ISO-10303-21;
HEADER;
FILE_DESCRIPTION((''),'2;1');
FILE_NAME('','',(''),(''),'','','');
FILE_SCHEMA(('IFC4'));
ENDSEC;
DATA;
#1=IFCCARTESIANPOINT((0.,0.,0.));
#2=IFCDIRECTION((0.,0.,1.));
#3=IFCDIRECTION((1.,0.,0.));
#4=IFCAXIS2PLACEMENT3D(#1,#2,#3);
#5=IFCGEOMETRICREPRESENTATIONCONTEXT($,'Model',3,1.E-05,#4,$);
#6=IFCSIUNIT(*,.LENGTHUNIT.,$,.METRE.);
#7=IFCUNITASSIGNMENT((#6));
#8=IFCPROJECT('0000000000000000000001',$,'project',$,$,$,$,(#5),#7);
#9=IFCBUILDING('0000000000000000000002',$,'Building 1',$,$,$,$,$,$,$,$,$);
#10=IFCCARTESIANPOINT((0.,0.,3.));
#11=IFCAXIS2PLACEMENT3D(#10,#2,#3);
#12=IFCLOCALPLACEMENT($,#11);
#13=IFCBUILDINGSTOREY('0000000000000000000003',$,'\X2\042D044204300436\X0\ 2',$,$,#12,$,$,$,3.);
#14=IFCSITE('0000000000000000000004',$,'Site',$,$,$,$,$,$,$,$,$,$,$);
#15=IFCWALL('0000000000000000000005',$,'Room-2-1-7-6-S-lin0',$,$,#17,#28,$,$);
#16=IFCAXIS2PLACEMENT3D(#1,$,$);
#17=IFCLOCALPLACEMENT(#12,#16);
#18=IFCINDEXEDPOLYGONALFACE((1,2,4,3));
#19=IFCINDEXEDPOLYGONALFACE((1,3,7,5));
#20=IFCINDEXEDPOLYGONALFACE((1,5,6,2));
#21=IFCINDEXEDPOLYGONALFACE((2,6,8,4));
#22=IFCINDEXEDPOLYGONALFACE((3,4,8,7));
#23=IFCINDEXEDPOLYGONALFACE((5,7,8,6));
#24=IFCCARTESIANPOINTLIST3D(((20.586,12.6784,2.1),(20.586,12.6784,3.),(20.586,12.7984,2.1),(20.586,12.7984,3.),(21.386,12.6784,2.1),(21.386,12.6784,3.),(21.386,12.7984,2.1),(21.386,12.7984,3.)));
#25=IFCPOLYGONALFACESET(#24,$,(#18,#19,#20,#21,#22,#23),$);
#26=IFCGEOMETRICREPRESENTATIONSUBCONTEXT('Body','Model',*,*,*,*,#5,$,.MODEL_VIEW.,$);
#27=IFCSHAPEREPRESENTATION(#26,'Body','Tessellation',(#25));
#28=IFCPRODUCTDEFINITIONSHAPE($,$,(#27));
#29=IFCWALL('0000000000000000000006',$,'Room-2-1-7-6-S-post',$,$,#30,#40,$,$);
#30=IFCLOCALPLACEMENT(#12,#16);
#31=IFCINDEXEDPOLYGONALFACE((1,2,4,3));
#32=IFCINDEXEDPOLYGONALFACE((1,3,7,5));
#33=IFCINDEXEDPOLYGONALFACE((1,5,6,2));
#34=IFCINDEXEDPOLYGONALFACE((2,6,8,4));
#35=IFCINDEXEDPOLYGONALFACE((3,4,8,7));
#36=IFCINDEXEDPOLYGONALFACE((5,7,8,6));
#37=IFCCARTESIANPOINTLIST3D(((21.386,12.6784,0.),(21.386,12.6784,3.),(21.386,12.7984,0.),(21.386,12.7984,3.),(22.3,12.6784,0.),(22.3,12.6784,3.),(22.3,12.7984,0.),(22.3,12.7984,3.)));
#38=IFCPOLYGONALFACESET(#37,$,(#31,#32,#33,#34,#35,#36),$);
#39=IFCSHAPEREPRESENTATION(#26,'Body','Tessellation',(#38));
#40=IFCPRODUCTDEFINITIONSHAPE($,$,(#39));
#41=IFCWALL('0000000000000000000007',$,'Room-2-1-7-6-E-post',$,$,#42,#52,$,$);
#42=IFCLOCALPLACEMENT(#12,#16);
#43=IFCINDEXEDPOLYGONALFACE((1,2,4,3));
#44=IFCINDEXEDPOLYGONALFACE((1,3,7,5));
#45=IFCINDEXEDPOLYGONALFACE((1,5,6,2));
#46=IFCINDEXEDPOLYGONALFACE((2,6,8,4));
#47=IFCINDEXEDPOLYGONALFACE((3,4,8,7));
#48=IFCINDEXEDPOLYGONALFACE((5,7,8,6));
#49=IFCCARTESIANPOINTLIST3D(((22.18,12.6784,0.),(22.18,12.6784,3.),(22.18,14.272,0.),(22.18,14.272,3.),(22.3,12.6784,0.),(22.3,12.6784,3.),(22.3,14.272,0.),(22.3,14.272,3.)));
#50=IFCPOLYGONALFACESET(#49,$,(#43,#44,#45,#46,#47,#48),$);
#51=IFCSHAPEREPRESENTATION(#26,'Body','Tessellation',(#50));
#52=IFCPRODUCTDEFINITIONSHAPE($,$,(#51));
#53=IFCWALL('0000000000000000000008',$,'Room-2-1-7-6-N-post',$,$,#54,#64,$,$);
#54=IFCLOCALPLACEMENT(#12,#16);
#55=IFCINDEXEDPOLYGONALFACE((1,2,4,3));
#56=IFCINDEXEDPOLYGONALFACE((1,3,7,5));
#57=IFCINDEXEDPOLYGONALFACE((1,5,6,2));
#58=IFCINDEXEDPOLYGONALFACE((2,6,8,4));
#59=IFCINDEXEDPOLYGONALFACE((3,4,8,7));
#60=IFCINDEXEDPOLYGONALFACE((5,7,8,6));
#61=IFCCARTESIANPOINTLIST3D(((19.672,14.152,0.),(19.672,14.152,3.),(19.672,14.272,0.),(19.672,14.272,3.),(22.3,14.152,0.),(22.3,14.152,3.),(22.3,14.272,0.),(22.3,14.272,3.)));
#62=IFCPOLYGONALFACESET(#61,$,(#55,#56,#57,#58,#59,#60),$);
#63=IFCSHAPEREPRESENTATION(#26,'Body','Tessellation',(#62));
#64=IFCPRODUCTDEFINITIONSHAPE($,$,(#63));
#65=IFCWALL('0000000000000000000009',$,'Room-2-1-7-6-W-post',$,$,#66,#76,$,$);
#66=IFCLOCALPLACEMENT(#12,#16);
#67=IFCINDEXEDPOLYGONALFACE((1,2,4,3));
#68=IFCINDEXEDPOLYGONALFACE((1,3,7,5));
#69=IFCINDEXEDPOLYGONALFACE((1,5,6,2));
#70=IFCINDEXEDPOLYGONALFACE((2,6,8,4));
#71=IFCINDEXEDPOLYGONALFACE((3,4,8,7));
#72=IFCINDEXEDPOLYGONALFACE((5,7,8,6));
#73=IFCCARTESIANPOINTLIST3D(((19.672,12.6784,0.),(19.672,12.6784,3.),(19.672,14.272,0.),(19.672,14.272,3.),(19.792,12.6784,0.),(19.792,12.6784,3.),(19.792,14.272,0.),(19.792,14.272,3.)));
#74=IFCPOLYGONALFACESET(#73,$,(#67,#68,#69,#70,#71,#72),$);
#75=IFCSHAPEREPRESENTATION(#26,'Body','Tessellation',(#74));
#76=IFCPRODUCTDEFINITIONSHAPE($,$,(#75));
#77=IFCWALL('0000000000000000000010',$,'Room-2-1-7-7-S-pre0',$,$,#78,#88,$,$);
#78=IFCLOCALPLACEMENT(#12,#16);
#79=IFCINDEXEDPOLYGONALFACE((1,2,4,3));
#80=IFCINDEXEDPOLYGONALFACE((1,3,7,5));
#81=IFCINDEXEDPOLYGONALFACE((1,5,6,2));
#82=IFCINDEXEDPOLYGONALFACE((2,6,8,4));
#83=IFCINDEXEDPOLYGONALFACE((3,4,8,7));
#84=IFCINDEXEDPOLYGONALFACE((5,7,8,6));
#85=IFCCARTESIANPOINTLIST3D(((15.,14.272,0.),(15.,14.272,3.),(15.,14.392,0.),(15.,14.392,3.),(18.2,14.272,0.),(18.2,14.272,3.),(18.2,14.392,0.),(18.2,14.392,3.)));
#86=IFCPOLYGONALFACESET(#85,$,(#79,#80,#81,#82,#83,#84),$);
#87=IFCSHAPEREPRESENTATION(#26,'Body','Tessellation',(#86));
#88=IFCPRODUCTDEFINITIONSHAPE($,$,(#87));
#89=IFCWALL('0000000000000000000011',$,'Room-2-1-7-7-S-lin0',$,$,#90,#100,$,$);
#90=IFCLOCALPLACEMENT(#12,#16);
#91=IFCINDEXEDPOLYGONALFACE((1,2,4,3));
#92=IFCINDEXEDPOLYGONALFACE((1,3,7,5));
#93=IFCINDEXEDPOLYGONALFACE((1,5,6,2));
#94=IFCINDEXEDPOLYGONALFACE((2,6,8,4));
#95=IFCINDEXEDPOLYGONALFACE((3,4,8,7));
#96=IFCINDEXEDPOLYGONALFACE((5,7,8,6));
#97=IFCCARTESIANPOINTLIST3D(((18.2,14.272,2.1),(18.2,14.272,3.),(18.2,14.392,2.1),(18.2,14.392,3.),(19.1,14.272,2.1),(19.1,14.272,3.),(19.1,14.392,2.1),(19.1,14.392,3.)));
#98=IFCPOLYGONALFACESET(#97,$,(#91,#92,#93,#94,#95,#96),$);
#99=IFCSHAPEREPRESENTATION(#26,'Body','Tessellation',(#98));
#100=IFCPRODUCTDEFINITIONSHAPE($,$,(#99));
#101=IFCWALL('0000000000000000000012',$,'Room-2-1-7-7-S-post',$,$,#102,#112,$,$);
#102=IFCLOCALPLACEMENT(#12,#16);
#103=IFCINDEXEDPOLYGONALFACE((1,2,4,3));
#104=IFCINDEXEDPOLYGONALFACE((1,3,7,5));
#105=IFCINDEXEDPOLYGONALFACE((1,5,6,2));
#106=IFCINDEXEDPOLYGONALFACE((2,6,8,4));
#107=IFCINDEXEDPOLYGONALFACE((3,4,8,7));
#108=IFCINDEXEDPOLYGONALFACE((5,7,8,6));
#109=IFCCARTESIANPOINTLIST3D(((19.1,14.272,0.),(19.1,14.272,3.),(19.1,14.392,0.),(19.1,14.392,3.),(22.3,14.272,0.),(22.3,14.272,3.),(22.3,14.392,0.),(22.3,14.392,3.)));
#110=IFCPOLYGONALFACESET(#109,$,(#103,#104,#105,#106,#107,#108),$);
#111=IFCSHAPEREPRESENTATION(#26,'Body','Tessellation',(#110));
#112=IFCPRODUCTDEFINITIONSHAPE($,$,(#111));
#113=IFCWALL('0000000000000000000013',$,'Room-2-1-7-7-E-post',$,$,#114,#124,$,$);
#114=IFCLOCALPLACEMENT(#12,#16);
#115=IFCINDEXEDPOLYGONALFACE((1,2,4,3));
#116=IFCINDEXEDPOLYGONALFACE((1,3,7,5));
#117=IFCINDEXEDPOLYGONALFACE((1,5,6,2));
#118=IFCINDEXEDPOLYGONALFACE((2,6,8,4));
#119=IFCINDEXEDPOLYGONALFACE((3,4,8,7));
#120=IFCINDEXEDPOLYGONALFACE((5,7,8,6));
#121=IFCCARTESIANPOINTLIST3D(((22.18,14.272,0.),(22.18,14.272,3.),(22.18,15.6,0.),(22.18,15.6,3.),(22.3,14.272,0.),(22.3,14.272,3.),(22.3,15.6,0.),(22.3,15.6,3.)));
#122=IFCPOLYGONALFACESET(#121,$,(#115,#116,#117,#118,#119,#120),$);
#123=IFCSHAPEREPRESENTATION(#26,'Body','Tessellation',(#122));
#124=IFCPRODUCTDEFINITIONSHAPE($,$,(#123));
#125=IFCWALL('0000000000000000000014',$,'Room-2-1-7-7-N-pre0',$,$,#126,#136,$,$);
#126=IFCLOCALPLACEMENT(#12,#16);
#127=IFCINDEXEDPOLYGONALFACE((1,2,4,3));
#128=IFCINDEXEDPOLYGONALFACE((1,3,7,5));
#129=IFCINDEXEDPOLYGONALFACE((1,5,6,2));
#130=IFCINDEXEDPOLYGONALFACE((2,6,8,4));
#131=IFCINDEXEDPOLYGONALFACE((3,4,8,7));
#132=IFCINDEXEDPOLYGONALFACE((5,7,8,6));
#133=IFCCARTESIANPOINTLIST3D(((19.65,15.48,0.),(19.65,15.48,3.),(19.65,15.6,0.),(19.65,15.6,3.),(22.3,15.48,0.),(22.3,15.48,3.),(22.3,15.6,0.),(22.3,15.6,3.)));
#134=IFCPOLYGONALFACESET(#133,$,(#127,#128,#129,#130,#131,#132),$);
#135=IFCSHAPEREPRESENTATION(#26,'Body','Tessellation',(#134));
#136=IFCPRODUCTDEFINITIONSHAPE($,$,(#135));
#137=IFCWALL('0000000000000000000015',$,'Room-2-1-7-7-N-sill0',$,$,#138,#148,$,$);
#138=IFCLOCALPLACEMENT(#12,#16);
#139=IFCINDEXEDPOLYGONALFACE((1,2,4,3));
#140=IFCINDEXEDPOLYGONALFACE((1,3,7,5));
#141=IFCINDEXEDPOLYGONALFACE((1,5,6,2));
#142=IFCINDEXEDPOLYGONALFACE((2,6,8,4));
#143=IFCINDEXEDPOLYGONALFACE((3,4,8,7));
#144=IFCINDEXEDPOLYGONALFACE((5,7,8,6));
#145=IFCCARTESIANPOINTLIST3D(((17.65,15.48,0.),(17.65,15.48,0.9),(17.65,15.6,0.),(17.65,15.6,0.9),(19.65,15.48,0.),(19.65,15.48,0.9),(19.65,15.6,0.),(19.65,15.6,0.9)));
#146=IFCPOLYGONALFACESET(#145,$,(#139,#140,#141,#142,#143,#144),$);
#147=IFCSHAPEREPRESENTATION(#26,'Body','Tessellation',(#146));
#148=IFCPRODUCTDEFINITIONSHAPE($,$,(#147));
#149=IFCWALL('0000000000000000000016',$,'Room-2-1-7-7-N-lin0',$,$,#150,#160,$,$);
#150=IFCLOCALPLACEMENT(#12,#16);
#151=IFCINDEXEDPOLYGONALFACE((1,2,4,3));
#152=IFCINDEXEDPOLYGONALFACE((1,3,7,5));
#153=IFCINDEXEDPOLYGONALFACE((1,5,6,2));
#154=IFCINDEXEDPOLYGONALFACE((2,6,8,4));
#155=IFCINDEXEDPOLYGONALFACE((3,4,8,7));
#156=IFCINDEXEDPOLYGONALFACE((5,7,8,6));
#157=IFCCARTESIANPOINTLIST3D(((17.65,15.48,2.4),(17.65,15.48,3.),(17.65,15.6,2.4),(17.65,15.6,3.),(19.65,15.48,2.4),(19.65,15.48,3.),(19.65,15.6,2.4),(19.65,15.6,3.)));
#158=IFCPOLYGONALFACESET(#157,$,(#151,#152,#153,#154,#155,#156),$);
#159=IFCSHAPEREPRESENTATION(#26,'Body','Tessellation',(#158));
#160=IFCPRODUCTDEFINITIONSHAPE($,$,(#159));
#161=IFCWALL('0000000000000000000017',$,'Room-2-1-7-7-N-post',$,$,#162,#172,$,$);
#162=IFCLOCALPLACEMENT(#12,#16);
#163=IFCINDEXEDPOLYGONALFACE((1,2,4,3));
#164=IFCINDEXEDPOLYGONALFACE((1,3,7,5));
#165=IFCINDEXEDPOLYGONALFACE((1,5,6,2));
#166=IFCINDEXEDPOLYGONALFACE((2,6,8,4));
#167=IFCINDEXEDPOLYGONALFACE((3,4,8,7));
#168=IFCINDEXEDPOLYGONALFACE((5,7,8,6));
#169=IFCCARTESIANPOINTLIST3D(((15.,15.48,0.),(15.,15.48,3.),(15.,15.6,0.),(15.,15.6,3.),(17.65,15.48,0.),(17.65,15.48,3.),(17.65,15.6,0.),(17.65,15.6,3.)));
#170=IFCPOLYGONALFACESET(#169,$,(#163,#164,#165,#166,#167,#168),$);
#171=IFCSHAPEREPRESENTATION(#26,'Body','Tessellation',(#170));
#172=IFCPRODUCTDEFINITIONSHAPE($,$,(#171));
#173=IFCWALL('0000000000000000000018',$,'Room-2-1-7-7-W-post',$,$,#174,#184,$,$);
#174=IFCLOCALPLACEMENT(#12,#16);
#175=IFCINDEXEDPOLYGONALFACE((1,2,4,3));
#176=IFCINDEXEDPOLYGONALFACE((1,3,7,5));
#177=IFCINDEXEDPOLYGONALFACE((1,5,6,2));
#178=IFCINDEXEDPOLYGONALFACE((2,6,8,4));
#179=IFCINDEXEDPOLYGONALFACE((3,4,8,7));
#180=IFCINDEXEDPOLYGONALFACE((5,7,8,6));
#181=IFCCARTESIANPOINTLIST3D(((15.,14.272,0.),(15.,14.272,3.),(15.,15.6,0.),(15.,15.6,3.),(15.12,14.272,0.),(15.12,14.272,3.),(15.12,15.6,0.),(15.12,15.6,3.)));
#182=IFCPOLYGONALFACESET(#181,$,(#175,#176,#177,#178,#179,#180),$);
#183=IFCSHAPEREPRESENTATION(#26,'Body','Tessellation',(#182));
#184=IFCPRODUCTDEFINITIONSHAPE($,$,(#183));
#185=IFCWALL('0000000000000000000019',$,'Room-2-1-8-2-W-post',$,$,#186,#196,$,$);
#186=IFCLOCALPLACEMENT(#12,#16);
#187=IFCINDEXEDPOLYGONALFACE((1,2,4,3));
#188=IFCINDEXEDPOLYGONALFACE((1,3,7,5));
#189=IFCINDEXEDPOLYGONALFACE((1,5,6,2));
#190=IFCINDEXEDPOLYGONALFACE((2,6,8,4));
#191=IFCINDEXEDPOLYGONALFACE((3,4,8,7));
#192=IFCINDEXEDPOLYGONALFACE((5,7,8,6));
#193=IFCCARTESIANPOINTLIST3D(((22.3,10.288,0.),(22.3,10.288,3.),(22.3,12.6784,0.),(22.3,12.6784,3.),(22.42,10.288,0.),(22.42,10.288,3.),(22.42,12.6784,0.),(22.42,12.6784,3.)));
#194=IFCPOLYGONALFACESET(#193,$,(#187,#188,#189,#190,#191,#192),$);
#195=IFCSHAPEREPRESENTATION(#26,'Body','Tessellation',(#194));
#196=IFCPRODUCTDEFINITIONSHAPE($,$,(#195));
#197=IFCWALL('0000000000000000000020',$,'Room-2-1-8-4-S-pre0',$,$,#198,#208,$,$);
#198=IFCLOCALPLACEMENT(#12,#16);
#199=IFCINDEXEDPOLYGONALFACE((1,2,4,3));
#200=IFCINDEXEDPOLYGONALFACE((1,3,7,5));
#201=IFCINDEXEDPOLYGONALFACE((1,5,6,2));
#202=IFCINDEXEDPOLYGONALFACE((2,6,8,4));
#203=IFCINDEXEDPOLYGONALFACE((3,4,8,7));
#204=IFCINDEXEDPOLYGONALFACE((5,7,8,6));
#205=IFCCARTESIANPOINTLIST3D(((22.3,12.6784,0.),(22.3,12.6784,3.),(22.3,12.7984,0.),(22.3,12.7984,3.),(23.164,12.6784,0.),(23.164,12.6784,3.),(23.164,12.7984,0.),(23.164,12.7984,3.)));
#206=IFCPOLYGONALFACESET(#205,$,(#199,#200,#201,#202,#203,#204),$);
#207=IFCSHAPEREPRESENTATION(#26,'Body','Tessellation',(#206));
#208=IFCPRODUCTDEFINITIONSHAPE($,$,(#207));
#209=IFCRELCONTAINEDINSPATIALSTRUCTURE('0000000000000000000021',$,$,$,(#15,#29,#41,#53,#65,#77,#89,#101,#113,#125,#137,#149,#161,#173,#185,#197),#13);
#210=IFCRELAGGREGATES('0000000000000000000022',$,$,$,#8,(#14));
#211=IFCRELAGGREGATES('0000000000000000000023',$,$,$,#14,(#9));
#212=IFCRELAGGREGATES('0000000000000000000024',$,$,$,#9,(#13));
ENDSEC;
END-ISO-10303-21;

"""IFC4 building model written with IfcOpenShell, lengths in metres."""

from ifc_helpers import new_model, si_unit, frame, origin_with_axes, place, context, subcontext, project, spatial, indexed_curve, outline, extrude, element, save


model = new_model("IFC4")

# Units and contexts
model_context = context("Model", 3, precision=1e-05, world=origin_with_axes())
body_context = subcontext(model_context, "Body", "Model", "MODEL_VIEW")
ifc_project = project(units=[si_unit("LENGTHUNIT", "METRE")], contexts=[model_context])

# Site, building, storey
site = spatial("IfcSite", under=ifc_project, Name="Site")
building = spatial("IfcBuilding", under=site, Name="Building 1")
storey_placement = place(None, frame((0.0, 0.0, 3.0), z_axis=(0.0, 0.0, 1.0), x_axis=(1.0, 0.0, 0.0)))
storey = spatial("IfcBuildingStorey", under=building, at=storey_placement, Name="Этаж 2", Elevation=3.0)

# Walls
wall_1_placement = place(storey_placement, frame((20.586, 12.6784, 2.1), z_axis=(0.0, 0.0, 1.0), x_axis=(1.0, 0.0, 0.0)))
element("IfcWall", 1, at=wall_1_placement, inside=storey, Name="Room-2-1-7-6-S-lin0", context=body_context, shape_type="SweptSolid", body=[
    extrude(outline(indexed_curve([(0.0, 0.0), (0.0, 0.12), (0.8, 0.12), (0.8, 0.0), (0.0, 0.0)], self_intersect=False)), origin_with_axes(), (0.0, 0.0, 1.0), 0.9),
])
wall_2_placement = place(storey_placement, frame((21.386, 12.6784, 0.0), z_axis=(0.0, 0.0, 1.0), x_axis=(1.0, 0.0, 0.0)))
element("IfcWall", 2, at=wall_2_placement, inside=storey, Name="Room-2-1-7-6-S-post", context=body_context, shape_type="SweptSolid", body=[
    extrude(outline(indexed_curve([(0.0, 0.0), (0.0, 0.12), (0.914, 0.12), (0.914, 0.0), (0.0, 0.0)], self_intersect=False)), origin_with_axes(), (0.0, 0.0, 1.0), 3.0),
])
wall_3_placement = place(storey_placement, frame((22.3, 12.6784, 0.0), z_axis=(0.0, 0.0, 1.0), x_axis=(0.0, 1.0, 0.0)))
element("IfcWall", 3, at=wall_3_placement, inside=storey, Name="Room-2-1-7-6-E-post", context=body_context, shape_type="SweptSolid", body=[
    extrude(outline(indexed_curve([(0.0, 0.0), (0.0, 0.12), (1.5936, 0.12), (1.5936, 0.0), (0.0, 0.0)], self_intersect=False)), origin_with_axes(), (0.0, 0.0, 1.0), 3.0),
])
wall_4_placement = place(storey_placement, frame((22.3, 14.272, 0.0), z_axis=(0.0, 0.0, 1.0), x_axis=(-1.0, 0.0, 0.0)))
element("IfcWall", 4, at=wall_4_placement, inside=storey, Name="Room-2-1-7-6-N-post", context=body_context, shape_type="SweptSolid", body=[
    extrude(outline(indexed_curve([(0.0, 0.0), (0.0, 0.12), (2.628, 0.12), (2.628, 0.0), (0.0, 0.0)], self_intersect=False)), origin_with_axes(), (0.0, 0.0, 1.0), 3.0),
])
wall_5_placement = place(storey_placement, frame((19.672, 14.272, 0.0), z_axis=(0.0, 0.0, 1.0), x_axis=(0.0, -1.0, 0.0)))
element("IfcWall", 5, at=wall_5_placement, inside=storey, Name="Room-2-1-7-6-W-post", context=body_context, shape_type="SweptSolid", body=[
    extrude(outline(indexed_curve([(0.0, 0.0), (0.0, 0.12), (1.5936, 0.12), (1.5936, 0.0), (0.0, 0.0)], self_intersect=False)), origin_with_axes(), (0.0, 0.0, 1.0), 3.0),
])
wall_6_placement = place(storey_placement, frame((15.0, 14.272, 0.0), z_axis=(0.0, 0.0, 1.0), x_axis=(1.0, 0.0, 0.0)))
element("IfcWall", 6, at=wall_6_placement, inside=storey, Name="Room-2-1-7-7-S-pre0", context=body_context, shape_type="SweptSolid", body=[
    extrude(outline(indexed_curve([(0.0, 0.0), (0.0, 0.12), (3.2, 0.12), (3.2, 0.0), (0.0, 0.0)], self_intersect=False)), origin_with_axes(), (0.0, 0.0, 1.0), 3.0),
])
wall_7_placement = place(storey_placement, frame((18.2, 14.272, 2.1), z_axis=(0.0, 0.0, 1.0), x_axis=(1.0, 0.0, 0.0)))
element("IfcWall", 7, at=wall_7_placement, inside=storey, Name="Room-2-1-7-7-S-lin0", context=body_context, shape_type="SweptSolid", body=[
    extrude(outline(indexed_curve([(0.0, 0.0), (0.0, 0.12), (0.9, 0.12), (0.9, 0.0), (0.0, 0.0)], self_intersect=False)), origin_with_axes(), (0.0, 0.0, 1.0), 0.9),
])
wall_8_placement = place(storey_placement, frame((19.1, 14.272, 0.0), z_axis=(0.0, 0.0, 1.0), x_axis=(1.0, 0.0, 0.0)))
element("IfcWall", 8, at=wall_8_placement, inside=storey, Name="Room-2-1-7-7-S-post", context=body_context, shape_type="SweptSolid", body=[
    extrude(outline(indexed_curve([(0.0, 0.0), (0.0, 0.12), (3.2, 0.12), (3.2, 0.0), (0.0, 0.0)], self_intersect=False)), origin_with_axes(), (0.0, 0.0, 1.0), 3.0),
])
wall_9_placement = place(storey_placement, frame((22.3, 14.272, 0.0), z_axis=(0.0, 0.0, 1.0), x_axis=(0.0, 1.0, 0.0)))
element("IfcWall", 9, at=wall_9_placement, inside=storey, Name="Room-2-1-7-7-E-post", context=body_context, shape_type="SweptSolid", body=[
    extrude(outline(indexed_curve([(0.0, 0.0), (0.0, 0.12), (1.328, 0.12), (1.328, 0.0), (0.0, 0.0)], self_intersect=False)), origin_with_axes(), (0.0, 0.0, 1.0), 3.0),
])
wall_10_placement = place(storey_placement, frame((22.3, 15.6, 0.0), z_axis=(0.0, 0.0, 1.0), x_axis=(-1.0, 0.0, 0.0)))
element("IfcWall", 10, at=wall_10_placement, inside=storey, Name="Room-2-1-7-7-N-pre0", context=body_context, shape_type="SweptSolid", body=[
    extrude(outline(indexed_curve([(0.0, 0.0), (0.0, 0.12), (2.65, 0.12), (2.65, 0.0), (0.0, 0.0)], self_intersect=False)), origin_with_axes(), (0.0, 0.0, 1.0), 3.0),
])
wall_11_placement = place(storey_placement, frame((19.65, 15.6, 0.0), z_axis=(0.0, 0.0, 1.0), x_axis=(-1.0, 0.0, 0.0)))
element("IfcWall", 11, at=wall_11_placement, inside=storey, Name="Room-2-1-7-7-N-sill0", context=body_context, shape_type="SweptSolid", body=[
    extrude(outline(indexed_curve([(0.0, 0.0), (0.0, 0.12), (2.0, 0.12), (2.0, 0.0), (0.0, 0.0)], self_intersect=False)), origin_with_axes(), (0.0, 0.0, 1.0), 0.9),
])
wall_12_placement = place(storey_placement, frame((19.65, 15.6, 2.4), z_axis=(0.0, 0.0, 1.0), x_axis=(-1.0, 0.0, 0.0)))
element("IfcWall", 12, at=wall_12_placement, inside=storey, Name="Room-2-1-7-7-N-lin0", context=body_context, shape_type="SweptSolid", body=[
    extrude(outline(indexed_curve([(0.0, 0.0), (0.0, 0.12), (2.0, 0.12), (2.0, 0.0), (0.0, 0.0)], self_intersect=False)), origin_with_axes(), (0.0, 0.0, 1.0), 0.6),
])
wall_13_placement = place(storey_placement, frame((17.65, 15.6, 0.0), z_axis=(0.0, 0.0, 1.0), x_axis=(-1.0, 0.0, 0.0)))
element("IfcWall", 13, at=wall_13_placement, inside=storey, Name="Room-2-1-7-7-N-post", context=body_context, shape_type="SweptSolid", body=[
    extrude(outline(indexed_curve([(0.0, 0.0), (0.0, 0.12), (2.65, 0.12), (2.65, 0.0), (0.0, 0.0)], self_intersect=False)), origin_with_axes(), (0.0, 0.0, 1.0), 3.0),
])
wall_14_placement = place(storey_placement, frame((15.0, 15.6, 0.0), z_axis=(0.0, 0.0, 1.0), x_axis=(0.0, -1.0, 0.0)))
element("IfcWall", 14, at=wall_14_placement, inside=storey, Name="Room-2-1-7-7-W-post", context=body_context, shape_type="SweptSolid", body=[
    extrude(outline(indexed_curve([(0.0, 0.0), (0.0, 0.12), (1.328, 0.12), (1.328, 0.0), (0.0, 0.0)], self_intersect=False)), origin_with_axes(), (0.0, 0.0, 1.0), 3.0),
])
wall_15_placement = place(storey_placement, frame((22.3, 12.6784, 0.0), z_axis=(0.0, 0.0, 1.0), x_axis=(0.0, -1.0, 0.0)))
element("IfcWall", 15, at=wall_15_placement, inside=storey, Name="Room-2-1-8-2-W-post", context=body_context, shape_type="SweptSolid", body=[
    extrude(outline(indexed_curve([(0.0, 0.0), (0.0, 0.12), (2.3904, 0.12), (2.3904, 0.0), (0.0, 0.0)], self_intersect=False)), origin_with_axes(), (0.0, 0.0, 1.0), 3.0),
])
wall_16_placement = place(storey_placement, frame((22.3, 12.6784, 0.0), z_axis=(0.0, 0.0, 1.0), x_axis=(1.0, 0.0, 0.0)))
element("IfcWall", 16, at=wall_16_placement, inside=storey, Name="Room-2-1-8-4-S-pre0", context=body_context, shape_type="SweptSolid", body=[
    extrude(outline(indexed_curve([(0.0, 0.0), (0.0, 0.12), (0.864, 0.12), (0.864, 0.0), (0.0, 0.0)], self_intersect=False)), origin_with_axes(), (0.0, 0.0, 1.0), 3.0),
])

save(model, "model.ifc")
